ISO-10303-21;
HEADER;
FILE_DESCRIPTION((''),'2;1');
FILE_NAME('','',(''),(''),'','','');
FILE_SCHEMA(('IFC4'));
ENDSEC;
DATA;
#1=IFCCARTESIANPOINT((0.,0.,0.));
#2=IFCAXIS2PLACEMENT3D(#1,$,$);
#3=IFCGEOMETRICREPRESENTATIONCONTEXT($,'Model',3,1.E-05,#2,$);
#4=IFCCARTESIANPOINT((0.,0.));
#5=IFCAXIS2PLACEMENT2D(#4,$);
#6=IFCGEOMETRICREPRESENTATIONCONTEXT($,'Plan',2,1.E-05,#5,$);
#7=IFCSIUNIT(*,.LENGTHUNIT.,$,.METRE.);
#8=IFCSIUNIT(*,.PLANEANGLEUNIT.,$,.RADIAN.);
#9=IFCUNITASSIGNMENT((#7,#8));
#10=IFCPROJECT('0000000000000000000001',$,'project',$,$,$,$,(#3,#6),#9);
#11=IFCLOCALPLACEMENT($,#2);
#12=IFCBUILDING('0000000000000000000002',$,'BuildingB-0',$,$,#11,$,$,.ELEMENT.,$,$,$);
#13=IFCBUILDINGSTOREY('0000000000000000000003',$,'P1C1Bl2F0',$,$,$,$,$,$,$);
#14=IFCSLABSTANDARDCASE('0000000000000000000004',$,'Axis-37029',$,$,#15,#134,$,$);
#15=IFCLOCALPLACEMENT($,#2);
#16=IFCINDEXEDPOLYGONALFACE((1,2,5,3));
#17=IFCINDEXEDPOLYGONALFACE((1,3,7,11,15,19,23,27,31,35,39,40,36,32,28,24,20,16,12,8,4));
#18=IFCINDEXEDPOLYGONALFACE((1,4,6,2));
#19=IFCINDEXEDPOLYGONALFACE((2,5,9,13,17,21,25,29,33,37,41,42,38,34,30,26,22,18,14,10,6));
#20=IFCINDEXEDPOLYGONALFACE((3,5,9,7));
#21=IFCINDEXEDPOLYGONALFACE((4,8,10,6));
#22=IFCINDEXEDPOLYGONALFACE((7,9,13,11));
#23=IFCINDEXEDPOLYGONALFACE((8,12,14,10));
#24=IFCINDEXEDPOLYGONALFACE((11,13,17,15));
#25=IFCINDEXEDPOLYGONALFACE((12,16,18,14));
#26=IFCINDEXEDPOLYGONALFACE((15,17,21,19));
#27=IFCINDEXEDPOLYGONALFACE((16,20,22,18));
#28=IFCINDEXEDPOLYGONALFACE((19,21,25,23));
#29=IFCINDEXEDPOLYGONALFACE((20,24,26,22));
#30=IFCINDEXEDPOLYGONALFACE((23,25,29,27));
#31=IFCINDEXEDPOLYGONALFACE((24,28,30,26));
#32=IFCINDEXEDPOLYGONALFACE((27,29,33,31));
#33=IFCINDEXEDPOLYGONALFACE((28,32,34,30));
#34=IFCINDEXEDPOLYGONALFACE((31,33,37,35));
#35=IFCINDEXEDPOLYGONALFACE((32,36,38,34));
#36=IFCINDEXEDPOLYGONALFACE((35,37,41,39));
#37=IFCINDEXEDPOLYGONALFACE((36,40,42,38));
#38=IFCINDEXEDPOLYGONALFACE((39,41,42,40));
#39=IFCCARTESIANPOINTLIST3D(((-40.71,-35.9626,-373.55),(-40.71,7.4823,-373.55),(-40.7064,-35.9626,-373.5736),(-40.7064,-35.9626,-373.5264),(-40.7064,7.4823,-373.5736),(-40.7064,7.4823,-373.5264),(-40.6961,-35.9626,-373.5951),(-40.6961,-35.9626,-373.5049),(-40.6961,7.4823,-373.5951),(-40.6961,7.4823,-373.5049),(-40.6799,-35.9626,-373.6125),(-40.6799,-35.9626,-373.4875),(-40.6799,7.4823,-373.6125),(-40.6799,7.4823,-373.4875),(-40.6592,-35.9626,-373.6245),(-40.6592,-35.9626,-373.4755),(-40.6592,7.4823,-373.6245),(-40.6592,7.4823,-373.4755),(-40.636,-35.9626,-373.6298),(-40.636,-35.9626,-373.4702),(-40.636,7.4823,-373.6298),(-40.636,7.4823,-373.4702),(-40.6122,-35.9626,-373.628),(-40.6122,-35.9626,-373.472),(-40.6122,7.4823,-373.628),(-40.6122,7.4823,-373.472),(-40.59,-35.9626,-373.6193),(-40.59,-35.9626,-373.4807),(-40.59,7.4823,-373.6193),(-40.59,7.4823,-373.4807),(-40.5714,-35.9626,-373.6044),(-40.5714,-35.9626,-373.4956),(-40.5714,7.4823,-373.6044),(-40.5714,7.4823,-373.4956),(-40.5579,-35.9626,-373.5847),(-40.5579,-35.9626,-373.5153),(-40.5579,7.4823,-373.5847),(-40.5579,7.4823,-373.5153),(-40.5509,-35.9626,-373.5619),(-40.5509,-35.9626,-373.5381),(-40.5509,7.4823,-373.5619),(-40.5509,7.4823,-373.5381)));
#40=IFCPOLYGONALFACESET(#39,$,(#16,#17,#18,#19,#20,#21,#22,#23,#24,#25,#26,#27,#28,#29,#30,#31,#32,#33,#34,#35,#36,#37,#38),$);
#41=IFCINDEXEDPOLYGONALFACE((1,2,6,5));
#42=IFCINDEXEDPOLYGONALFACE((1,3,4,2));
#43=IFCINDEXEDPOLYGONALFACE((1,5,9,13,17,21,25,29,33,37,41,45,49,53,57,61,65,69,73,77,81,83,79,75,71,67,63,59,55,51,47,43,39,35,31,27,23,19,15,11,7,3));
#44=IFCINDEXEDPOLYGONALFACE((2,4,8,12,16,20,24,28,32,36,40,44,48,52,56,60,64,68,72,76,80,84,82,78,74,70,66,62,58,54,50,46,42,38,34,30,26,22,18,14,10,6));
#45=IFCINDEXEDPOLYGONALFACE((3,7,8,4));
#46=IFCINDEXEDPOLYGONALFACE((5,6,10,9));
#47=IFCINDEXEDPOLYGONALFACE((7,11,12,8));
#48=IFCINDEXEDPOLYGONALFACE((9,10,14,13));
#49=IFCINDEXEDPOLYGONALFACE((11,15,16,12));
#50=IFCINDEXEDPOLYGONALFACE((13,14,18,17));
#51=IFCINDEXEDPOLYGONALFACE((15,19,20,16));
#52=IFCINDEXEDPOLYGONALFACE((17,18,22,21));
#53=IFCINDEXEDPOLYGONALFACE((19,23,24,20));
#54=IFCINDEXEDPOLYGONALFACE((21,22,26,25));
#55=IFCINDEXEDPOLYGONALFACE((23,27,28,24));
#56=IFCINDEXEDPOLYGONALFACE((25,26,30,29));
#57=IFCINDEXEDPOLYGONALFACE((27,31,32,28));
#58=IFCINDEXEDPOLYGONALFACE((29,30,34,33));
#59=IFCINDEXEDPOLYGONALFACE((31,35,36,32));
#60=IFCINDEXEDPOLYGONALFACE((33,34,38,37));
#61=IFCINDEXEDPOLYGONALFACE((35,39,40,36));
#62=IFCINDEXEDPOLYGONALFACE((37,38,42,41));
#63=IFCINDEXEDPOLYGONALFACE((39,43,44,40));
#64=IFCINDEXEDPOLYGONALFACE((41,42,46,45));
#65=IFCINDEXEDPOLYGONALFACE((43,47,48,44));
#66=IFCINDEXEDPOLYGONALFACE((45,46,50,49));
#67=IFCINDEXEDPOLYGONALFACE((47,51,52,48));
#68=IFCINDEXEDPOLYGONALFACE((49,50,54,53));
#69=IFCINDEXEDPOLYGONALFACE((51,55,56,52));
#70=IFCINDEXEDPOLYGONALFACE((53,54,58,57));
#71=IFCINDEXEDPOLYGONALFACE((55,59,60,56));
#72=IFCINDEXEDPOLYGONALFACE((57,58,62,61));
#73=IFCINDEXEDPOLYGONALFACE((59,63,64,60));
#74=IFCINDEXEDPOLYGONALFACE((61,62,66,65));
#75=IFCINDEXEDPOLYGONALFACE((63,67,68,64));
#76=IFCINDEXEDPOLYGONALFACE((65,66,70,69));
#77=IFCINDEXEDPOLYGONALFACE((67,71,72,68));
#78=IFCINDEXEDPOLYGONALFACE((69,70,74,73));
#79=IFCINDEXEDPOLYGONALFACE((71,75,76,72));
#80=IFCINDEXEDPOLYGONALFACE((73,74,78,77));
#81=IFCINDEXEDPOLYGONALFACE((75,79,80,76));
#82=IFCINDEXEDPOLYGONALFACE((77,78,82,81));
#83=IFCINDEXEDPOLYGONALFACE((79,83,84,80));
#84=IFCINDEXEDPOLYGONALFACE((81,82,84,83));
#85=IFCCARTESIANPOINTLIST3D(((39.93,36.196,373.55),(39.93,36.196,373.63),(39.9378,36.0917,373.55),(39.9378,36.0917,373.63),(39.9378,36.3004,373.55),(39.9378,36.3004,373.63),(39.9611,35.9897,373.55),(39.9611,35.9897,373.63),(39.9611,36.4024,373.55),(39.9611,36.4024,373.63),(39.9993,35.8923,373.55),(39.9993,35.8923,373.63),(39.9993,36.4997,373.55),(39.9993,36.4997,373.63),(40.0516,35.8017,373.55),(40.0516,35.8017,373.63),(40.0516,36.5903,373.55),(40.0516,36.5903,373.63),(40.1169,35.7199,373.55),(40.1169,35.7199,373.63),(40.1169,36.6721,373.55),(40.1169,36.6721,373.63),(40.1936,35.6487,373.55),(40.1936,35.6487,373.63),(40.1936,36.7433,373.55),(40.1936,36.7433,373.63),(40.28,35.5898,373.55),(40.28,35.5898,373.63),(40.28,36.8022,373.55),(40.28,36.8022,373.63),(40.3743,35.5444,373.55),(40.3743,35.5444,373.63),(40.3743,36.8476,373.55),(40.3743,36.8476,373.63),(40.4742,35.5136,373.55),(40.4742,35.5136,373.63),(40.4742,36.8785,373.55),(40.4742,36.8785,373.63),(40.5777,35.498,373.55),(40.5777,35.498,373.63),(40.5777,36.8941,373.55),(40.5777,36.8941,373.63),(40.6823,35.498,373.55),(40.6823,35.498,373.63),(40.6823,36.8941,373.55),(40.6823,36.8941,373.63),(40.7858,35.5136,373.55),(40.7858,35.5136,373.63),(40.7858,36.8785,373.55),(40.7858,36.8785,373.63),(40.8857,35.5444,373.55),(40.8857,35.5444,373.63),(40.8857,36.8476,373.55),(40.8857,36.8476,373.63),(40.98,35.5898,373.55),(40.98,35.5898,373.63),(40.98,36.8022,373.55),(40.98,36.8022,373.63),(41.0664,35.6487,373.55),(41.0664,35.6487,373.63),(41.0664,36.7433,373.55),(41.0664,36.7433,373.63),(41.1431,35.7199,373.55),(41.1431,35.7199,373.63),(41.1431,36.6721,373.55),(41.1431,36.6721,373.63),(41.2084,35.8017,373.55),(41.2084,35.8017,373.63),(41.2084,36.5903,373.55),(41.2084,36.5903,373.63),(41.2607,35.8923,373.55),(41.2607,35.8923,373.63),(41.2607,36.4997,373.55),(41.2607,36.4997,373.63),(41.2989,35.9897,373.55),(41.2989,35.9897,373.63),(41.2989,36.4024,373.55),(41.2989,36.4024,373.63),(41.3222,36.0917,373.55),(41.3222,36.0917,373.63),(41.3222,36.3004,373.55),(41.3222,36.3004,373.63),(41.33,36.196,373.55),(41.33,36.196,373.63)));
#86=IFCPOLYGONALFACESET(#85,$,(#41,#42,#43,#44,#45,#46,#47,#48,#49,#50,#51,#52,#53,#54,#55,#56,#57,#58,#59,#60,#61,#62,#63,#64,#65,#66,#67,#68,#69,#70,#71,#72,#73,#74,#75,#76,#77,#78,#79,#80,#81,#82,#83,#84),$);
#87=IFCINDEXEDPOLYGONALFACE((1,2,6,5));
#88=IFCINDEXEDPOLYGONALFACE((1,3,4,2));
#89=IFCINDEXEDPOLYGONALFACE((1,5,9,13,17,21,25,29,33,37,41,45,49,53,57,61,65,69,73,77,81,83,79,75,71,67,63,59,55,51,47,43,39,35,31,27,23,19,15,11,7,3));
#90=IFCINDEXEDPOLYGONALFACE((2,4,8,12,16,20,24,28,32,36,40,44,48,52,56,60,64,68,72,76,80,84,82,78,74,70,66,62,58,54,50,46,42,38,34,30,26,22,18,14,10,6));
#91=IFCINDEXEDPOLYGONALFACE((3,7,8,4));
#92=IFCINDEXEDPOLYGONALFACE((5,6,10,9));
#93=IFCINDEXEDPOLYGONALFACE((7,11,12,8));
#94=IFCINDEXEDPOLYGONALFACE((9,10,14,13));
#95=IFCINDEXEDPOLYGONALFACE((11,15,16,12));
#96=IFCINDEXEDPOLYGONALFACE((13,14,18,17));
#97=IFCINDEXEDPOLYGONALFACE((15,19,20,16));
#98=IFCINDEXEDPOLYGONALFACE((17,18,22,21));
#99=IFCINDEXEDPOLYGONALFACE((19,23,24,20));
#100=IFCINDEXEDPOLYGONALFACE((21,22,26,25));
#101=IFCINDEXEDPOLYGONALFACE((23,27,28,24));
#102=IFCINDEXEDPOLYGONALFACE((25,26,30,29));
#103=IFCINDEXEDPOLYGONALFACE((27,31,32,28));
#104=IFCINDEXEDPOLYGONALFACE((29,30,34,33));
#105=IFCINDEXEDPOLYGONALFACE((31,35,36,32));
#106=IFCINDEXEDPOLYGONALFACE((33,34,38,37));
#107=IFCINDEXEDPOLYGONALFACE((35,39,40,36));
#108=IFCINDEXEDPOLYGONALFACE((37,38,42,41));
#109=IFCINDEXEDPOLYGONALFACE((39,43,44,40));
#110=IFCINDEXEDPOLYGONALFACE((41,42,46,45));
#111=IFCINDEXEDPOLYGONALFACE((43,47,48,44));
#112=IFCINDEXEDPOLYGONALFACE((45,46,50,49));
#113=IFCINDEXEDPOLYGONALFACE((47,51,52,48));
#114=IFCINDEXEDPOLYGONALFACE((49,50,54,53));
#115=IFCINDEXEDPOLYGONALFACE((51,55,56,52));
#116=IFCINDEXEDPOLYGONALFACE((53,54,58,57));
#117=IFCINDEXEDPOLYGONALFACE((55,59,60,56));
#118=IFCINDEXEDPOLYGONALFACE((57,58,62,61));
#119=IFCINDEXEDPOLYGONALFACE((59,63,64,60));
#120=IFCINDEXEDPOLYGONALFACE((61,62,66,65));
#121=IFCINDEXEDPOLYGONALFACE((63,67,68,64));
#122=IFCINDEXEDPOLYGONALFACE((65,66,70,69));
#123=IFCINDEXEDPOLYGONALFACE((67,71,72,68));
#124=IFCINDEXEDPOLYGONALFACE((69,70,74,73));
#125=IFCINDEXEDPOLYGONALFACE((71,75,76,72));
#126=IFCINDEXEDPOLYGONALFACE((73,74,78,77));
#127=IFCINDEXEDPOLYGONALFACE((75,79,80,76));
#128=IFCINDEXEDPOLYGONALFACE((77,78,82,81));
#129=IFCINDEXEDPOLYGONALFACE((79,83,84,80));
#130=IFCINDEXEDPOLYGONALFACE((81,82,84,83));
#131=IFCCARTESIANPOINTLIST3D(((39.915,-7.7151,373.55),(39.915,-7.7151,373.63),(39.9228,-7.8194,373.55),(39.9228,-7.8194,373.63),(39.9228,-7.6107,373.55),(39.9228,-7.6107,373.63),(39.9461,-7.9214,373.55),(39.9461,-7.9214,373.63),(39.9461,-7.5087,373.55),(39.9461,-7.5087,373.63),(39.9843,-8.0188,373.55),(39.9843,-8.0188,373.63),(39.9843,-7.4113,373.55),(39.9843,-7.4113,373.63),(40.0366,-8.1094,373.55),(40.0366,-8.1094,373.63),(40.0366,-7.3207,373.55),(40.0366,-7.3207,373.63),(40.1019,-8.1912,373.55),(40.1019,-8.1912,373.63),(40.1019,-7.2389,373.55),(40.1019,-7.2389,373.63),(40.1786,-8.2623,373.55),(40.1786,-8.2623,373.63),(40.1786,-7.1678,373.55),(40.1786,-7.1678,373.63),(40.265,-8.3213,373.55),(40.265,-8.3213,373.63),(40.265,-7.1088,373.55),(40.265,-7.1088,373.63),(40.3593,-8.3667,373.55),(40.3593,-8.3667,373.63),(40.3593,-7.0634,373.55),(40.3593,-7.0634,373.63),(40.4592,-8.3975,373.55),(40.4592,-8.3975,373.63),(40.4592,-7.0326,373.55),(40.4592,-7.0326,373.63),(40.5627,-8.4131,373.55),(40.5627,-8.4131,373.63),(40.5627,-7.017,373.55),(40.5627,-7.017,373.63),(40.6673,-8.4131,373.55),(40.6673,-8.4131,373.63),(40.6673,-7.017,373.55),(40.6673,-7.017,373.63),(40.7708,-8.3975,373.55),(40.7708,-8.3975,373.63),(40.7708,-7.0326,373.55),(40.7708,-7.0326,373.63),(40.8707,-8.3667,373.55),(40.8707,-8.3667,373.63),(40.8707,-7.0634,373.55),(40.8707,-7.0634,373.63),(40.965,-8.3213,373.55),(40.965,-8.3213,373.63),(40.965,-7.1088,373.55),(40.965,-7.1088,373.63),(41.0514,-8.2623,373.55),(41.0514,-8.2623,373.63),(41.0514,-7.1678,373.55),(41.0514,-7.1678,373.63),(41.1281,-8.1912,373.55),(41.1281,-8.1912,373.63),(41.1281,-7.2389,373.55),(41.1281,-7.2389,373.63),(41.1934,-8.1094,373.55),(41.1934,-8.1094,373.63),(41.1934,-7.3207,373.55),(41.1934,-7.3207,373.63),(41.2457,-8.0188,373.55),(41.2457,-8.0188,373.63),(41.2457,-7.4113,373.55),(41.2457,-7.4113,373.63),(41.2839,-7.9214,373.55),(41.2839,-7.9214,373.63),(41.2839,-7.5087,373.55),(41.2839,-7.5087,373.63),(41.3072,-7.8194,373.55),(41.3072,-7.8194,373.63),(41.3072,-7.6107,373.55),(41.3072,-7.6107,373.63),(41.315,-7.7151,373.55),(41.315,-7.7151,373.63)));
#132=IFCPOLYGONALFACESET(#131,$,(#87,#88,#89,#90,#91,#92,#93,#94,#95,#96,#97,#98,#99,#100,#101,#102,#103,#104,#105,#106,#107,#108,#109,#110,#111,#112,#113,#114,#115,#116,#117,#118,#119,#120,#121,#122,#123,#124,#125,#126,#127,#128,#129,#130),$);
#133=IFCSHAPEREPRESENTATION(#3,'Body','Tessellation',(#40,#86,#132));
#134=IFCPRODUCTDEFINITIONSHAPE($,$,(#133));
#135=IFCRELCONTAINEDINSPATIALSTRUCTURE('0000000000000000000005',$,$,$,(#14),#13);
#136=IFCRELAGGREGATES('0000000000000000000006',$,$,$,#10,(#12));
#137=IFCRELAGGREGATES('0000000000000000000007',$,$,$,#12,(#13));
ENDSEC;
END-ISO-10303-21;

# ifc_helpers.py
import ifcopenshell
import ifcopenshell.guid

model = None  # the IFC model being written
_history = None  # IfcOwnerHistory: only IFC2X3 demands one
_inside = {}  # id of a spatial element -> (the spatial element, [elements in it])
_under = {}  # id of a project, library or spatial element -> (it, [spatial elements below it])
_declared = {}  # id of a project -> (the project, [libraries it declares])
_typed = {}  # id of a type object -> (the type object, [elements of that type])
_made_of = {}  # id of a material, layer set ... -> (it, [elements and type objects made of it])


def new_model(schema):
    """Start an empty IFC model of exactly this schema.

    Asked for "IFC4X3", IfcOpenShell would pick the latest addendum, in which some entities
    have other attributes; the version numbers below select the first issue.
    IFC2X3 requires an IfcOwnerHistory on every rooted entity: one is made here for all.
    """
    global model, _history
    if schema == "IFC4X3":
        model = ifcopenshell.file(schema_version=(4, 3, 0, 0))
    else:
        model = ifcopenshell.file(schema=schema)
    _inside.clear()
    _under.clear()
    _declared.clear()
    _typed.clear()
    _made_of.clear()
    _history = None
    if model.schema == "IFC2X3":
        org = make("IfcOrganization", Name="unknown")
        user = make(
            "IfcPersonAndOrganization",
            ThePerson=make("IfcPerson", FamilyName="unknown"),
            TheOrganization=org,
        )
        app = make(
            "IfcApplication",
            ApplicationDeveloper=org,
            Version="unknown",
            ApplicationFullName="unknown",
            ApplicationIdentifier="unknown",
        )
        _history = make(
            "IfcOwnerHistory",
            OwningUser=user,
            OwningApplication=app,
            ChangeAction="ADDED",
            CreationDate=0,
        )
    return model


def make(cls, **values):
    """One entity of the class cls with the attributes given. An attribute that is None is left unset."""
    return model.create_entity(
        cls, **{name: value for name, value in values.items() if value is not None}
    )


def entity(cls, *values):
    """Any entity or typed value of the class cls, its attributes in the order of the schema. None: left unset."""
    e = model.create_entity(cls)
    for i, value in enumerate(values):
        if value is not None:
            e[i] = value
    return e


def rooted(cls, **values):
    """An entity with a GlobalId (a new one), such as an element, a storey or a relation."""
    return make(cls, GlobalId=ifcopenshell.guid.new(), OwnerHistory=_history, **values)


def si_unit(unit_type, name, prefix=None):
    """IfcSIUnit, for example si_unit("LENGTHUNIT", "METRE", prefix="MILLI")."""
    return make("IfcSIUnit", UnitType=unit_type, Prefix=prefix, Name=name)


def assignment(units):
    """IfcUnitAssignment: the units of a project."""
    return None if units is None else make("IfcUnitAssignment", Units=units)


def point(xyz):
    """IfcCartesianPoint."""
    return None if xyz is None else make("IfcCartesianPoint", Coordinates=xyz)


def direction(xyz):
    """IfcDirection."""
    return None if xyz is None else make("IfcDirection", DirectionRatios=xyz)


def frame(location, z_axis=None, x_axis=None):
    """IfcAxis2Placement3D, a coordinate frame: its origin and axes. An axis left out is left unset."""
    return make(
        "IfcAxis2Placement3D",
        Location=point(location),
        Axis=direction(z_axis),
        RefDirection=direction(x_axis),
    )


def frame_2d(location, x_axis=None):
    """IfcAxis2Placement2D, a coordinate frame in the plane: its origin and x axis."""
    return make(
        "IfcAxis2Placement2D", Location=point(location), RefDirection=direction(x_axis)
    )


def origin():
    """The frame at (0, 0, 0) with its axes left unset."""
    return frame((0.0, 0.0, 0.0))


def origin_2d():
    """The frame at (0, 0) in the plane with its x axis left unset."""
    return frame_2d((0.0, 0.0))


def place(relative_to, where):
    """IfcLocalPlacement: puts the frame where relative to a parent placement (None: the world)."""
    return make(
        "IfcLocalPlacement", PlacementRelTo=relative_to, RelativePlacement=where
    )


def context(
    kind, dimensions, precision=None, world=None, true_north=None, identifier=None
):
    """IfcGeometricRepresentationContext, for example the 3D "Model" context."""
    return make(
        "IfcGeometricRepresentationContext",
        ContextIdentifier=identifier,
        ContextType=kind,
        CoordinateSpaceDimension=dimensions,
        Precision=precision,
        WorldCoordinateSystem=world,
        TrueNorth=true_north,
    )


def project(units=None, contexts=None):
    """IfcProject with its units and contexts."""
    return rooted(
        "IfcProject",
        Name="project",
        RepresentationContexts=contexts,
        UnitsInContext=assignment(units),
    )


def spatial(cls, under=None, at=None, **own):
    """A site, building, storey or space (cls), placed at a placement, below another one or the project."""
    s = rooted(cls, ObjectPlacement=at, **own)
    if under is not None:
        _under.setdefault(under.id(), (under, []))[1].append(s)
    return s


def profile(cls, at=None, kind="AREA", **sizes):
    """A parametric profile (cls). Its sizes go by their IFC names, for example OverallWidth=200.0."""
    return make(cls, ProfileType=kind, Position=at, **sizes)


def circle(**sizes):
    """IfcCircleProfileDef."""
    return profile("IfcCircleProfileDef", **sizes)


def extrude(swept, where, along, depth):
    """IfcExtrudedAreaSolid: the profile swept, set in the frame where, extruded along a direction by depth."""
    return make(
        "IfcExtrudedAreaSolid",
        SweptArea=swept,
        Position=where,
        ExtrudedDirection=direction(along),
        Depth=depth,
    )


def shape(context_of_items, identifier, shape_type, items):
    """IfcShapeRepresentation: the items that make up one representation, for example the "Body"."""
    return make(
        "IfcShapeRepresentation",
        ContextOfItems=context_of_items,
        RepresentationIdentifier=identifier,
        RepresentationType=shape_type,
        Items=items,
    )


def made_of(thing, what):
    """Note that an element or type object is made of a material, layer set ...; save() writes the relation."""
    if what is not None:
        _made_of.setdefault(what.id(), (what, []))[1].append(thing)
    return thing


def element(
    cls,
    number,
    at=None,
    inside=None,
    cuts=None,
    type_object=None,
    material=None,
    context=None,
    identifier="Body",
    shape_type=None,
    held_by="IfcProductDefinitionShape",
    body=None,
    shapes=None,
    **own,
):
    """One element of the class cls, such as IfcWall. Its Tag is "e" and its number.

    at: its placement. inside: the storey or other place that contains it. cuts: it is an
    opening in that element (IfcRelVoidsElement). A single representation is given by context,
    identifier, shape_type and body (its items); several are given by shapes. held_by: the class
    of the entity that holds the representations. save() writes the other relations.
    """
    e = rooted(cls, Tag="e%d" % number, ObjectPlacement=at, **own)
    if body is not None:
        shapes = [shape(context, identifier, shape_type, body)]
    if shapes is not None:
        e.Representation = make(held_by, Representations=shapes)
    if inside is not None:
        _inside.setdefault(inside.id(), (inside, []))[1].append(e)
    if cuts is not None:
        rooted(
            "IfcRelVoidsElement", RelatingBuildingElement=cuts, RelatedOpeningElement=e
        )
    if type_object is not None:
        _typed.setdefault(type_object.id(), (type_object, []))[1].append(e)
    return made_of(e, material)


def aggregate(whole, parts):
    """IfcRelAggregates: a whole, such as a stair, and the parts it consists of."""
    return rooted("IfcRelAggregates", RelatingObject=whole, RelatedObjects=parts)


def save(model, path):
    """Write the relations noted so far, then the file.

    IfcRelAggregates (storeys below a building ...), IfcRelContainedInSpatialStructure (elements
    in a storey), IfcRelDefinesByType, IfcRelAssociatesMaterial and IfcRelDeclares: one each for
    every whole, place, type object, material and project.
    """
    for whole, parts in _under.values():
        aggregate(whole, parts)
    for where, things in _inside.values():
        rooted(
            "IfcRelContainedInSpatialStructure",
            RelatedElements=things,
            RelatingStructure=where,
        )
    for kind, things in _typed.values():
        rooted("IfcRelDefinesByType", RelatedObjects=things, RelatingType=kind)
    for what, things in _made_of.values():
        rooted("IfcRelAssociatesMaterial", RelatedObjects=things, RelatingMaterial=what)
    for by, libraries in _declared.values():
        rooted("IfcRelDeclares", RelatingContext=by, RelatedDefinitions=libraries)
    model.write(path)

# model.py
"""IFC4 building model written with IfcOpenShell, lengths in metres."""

from ifc_helpers import new_model, entity, si_unit, frame, origin, origin_2d, place, context, project, spatial, circle, extrude, element, save


model = new_model("IFC4")

# Units and contexts
model_context = context("Model", 3, precision=1e-05, world=origin())
plan_context = context("Plan", 2, precision=1e-05, world=origin_2d())
ifc_project = project(units=[si_unit("LENGTHUNIT", "METRE"), si_unit("PLANEANGLEUNIT", "RADIAN")], contexts=[model_context, plan_context])

# Building, storey
building_placement = place(None, origin())
building = spatial("IfcBuilding", under=ifc_project, at=building_placement, Name="BuildingB-0", CompositionType="ELEMENT")
storey = spatial("IfcBuildingStorey", under=building, Name="P1C1Bl2F0")

# Slab
element("IfcSlabStandardCase", 1, inside=storey, Name="Axis-37029", context=model_context, shape_type="AdvancedSweptSolid", body=[
    entity("IfcSurfaceCurveSweptAreaSolid", entity("IfcCircleProfileDef", "AREA", None, None, 0.08), None, entity("IfcPolyline", [entity("IfcCartesianPoint", [40.63, 35.9626, 373.55]), entity("IfcCartesianPoint", [40.63, -7.4823, 373.55])]), None, None, entity("IfcPlane", entity("IfcAxis2Placement3D", entity("IfcCartesianPoint", [40.63, 35.9626, 373.55]), entity("IfcDirection", [0.0, 0.0, 1.0]), entity("IfcDirection", [1.0, 0.0, 0.0])))),
    extrude(circle(Radius=0.7), frame((40.63, 36.196, 373.55)), (0.0, 0.0, 1.0), 0.08),
    extrude(circle(Radius=0.7), frame((40.615, -7.7151, 373.55)), (0.0, 0.0, 1.0), 0.08),
])

save(model, "model.ifc")
